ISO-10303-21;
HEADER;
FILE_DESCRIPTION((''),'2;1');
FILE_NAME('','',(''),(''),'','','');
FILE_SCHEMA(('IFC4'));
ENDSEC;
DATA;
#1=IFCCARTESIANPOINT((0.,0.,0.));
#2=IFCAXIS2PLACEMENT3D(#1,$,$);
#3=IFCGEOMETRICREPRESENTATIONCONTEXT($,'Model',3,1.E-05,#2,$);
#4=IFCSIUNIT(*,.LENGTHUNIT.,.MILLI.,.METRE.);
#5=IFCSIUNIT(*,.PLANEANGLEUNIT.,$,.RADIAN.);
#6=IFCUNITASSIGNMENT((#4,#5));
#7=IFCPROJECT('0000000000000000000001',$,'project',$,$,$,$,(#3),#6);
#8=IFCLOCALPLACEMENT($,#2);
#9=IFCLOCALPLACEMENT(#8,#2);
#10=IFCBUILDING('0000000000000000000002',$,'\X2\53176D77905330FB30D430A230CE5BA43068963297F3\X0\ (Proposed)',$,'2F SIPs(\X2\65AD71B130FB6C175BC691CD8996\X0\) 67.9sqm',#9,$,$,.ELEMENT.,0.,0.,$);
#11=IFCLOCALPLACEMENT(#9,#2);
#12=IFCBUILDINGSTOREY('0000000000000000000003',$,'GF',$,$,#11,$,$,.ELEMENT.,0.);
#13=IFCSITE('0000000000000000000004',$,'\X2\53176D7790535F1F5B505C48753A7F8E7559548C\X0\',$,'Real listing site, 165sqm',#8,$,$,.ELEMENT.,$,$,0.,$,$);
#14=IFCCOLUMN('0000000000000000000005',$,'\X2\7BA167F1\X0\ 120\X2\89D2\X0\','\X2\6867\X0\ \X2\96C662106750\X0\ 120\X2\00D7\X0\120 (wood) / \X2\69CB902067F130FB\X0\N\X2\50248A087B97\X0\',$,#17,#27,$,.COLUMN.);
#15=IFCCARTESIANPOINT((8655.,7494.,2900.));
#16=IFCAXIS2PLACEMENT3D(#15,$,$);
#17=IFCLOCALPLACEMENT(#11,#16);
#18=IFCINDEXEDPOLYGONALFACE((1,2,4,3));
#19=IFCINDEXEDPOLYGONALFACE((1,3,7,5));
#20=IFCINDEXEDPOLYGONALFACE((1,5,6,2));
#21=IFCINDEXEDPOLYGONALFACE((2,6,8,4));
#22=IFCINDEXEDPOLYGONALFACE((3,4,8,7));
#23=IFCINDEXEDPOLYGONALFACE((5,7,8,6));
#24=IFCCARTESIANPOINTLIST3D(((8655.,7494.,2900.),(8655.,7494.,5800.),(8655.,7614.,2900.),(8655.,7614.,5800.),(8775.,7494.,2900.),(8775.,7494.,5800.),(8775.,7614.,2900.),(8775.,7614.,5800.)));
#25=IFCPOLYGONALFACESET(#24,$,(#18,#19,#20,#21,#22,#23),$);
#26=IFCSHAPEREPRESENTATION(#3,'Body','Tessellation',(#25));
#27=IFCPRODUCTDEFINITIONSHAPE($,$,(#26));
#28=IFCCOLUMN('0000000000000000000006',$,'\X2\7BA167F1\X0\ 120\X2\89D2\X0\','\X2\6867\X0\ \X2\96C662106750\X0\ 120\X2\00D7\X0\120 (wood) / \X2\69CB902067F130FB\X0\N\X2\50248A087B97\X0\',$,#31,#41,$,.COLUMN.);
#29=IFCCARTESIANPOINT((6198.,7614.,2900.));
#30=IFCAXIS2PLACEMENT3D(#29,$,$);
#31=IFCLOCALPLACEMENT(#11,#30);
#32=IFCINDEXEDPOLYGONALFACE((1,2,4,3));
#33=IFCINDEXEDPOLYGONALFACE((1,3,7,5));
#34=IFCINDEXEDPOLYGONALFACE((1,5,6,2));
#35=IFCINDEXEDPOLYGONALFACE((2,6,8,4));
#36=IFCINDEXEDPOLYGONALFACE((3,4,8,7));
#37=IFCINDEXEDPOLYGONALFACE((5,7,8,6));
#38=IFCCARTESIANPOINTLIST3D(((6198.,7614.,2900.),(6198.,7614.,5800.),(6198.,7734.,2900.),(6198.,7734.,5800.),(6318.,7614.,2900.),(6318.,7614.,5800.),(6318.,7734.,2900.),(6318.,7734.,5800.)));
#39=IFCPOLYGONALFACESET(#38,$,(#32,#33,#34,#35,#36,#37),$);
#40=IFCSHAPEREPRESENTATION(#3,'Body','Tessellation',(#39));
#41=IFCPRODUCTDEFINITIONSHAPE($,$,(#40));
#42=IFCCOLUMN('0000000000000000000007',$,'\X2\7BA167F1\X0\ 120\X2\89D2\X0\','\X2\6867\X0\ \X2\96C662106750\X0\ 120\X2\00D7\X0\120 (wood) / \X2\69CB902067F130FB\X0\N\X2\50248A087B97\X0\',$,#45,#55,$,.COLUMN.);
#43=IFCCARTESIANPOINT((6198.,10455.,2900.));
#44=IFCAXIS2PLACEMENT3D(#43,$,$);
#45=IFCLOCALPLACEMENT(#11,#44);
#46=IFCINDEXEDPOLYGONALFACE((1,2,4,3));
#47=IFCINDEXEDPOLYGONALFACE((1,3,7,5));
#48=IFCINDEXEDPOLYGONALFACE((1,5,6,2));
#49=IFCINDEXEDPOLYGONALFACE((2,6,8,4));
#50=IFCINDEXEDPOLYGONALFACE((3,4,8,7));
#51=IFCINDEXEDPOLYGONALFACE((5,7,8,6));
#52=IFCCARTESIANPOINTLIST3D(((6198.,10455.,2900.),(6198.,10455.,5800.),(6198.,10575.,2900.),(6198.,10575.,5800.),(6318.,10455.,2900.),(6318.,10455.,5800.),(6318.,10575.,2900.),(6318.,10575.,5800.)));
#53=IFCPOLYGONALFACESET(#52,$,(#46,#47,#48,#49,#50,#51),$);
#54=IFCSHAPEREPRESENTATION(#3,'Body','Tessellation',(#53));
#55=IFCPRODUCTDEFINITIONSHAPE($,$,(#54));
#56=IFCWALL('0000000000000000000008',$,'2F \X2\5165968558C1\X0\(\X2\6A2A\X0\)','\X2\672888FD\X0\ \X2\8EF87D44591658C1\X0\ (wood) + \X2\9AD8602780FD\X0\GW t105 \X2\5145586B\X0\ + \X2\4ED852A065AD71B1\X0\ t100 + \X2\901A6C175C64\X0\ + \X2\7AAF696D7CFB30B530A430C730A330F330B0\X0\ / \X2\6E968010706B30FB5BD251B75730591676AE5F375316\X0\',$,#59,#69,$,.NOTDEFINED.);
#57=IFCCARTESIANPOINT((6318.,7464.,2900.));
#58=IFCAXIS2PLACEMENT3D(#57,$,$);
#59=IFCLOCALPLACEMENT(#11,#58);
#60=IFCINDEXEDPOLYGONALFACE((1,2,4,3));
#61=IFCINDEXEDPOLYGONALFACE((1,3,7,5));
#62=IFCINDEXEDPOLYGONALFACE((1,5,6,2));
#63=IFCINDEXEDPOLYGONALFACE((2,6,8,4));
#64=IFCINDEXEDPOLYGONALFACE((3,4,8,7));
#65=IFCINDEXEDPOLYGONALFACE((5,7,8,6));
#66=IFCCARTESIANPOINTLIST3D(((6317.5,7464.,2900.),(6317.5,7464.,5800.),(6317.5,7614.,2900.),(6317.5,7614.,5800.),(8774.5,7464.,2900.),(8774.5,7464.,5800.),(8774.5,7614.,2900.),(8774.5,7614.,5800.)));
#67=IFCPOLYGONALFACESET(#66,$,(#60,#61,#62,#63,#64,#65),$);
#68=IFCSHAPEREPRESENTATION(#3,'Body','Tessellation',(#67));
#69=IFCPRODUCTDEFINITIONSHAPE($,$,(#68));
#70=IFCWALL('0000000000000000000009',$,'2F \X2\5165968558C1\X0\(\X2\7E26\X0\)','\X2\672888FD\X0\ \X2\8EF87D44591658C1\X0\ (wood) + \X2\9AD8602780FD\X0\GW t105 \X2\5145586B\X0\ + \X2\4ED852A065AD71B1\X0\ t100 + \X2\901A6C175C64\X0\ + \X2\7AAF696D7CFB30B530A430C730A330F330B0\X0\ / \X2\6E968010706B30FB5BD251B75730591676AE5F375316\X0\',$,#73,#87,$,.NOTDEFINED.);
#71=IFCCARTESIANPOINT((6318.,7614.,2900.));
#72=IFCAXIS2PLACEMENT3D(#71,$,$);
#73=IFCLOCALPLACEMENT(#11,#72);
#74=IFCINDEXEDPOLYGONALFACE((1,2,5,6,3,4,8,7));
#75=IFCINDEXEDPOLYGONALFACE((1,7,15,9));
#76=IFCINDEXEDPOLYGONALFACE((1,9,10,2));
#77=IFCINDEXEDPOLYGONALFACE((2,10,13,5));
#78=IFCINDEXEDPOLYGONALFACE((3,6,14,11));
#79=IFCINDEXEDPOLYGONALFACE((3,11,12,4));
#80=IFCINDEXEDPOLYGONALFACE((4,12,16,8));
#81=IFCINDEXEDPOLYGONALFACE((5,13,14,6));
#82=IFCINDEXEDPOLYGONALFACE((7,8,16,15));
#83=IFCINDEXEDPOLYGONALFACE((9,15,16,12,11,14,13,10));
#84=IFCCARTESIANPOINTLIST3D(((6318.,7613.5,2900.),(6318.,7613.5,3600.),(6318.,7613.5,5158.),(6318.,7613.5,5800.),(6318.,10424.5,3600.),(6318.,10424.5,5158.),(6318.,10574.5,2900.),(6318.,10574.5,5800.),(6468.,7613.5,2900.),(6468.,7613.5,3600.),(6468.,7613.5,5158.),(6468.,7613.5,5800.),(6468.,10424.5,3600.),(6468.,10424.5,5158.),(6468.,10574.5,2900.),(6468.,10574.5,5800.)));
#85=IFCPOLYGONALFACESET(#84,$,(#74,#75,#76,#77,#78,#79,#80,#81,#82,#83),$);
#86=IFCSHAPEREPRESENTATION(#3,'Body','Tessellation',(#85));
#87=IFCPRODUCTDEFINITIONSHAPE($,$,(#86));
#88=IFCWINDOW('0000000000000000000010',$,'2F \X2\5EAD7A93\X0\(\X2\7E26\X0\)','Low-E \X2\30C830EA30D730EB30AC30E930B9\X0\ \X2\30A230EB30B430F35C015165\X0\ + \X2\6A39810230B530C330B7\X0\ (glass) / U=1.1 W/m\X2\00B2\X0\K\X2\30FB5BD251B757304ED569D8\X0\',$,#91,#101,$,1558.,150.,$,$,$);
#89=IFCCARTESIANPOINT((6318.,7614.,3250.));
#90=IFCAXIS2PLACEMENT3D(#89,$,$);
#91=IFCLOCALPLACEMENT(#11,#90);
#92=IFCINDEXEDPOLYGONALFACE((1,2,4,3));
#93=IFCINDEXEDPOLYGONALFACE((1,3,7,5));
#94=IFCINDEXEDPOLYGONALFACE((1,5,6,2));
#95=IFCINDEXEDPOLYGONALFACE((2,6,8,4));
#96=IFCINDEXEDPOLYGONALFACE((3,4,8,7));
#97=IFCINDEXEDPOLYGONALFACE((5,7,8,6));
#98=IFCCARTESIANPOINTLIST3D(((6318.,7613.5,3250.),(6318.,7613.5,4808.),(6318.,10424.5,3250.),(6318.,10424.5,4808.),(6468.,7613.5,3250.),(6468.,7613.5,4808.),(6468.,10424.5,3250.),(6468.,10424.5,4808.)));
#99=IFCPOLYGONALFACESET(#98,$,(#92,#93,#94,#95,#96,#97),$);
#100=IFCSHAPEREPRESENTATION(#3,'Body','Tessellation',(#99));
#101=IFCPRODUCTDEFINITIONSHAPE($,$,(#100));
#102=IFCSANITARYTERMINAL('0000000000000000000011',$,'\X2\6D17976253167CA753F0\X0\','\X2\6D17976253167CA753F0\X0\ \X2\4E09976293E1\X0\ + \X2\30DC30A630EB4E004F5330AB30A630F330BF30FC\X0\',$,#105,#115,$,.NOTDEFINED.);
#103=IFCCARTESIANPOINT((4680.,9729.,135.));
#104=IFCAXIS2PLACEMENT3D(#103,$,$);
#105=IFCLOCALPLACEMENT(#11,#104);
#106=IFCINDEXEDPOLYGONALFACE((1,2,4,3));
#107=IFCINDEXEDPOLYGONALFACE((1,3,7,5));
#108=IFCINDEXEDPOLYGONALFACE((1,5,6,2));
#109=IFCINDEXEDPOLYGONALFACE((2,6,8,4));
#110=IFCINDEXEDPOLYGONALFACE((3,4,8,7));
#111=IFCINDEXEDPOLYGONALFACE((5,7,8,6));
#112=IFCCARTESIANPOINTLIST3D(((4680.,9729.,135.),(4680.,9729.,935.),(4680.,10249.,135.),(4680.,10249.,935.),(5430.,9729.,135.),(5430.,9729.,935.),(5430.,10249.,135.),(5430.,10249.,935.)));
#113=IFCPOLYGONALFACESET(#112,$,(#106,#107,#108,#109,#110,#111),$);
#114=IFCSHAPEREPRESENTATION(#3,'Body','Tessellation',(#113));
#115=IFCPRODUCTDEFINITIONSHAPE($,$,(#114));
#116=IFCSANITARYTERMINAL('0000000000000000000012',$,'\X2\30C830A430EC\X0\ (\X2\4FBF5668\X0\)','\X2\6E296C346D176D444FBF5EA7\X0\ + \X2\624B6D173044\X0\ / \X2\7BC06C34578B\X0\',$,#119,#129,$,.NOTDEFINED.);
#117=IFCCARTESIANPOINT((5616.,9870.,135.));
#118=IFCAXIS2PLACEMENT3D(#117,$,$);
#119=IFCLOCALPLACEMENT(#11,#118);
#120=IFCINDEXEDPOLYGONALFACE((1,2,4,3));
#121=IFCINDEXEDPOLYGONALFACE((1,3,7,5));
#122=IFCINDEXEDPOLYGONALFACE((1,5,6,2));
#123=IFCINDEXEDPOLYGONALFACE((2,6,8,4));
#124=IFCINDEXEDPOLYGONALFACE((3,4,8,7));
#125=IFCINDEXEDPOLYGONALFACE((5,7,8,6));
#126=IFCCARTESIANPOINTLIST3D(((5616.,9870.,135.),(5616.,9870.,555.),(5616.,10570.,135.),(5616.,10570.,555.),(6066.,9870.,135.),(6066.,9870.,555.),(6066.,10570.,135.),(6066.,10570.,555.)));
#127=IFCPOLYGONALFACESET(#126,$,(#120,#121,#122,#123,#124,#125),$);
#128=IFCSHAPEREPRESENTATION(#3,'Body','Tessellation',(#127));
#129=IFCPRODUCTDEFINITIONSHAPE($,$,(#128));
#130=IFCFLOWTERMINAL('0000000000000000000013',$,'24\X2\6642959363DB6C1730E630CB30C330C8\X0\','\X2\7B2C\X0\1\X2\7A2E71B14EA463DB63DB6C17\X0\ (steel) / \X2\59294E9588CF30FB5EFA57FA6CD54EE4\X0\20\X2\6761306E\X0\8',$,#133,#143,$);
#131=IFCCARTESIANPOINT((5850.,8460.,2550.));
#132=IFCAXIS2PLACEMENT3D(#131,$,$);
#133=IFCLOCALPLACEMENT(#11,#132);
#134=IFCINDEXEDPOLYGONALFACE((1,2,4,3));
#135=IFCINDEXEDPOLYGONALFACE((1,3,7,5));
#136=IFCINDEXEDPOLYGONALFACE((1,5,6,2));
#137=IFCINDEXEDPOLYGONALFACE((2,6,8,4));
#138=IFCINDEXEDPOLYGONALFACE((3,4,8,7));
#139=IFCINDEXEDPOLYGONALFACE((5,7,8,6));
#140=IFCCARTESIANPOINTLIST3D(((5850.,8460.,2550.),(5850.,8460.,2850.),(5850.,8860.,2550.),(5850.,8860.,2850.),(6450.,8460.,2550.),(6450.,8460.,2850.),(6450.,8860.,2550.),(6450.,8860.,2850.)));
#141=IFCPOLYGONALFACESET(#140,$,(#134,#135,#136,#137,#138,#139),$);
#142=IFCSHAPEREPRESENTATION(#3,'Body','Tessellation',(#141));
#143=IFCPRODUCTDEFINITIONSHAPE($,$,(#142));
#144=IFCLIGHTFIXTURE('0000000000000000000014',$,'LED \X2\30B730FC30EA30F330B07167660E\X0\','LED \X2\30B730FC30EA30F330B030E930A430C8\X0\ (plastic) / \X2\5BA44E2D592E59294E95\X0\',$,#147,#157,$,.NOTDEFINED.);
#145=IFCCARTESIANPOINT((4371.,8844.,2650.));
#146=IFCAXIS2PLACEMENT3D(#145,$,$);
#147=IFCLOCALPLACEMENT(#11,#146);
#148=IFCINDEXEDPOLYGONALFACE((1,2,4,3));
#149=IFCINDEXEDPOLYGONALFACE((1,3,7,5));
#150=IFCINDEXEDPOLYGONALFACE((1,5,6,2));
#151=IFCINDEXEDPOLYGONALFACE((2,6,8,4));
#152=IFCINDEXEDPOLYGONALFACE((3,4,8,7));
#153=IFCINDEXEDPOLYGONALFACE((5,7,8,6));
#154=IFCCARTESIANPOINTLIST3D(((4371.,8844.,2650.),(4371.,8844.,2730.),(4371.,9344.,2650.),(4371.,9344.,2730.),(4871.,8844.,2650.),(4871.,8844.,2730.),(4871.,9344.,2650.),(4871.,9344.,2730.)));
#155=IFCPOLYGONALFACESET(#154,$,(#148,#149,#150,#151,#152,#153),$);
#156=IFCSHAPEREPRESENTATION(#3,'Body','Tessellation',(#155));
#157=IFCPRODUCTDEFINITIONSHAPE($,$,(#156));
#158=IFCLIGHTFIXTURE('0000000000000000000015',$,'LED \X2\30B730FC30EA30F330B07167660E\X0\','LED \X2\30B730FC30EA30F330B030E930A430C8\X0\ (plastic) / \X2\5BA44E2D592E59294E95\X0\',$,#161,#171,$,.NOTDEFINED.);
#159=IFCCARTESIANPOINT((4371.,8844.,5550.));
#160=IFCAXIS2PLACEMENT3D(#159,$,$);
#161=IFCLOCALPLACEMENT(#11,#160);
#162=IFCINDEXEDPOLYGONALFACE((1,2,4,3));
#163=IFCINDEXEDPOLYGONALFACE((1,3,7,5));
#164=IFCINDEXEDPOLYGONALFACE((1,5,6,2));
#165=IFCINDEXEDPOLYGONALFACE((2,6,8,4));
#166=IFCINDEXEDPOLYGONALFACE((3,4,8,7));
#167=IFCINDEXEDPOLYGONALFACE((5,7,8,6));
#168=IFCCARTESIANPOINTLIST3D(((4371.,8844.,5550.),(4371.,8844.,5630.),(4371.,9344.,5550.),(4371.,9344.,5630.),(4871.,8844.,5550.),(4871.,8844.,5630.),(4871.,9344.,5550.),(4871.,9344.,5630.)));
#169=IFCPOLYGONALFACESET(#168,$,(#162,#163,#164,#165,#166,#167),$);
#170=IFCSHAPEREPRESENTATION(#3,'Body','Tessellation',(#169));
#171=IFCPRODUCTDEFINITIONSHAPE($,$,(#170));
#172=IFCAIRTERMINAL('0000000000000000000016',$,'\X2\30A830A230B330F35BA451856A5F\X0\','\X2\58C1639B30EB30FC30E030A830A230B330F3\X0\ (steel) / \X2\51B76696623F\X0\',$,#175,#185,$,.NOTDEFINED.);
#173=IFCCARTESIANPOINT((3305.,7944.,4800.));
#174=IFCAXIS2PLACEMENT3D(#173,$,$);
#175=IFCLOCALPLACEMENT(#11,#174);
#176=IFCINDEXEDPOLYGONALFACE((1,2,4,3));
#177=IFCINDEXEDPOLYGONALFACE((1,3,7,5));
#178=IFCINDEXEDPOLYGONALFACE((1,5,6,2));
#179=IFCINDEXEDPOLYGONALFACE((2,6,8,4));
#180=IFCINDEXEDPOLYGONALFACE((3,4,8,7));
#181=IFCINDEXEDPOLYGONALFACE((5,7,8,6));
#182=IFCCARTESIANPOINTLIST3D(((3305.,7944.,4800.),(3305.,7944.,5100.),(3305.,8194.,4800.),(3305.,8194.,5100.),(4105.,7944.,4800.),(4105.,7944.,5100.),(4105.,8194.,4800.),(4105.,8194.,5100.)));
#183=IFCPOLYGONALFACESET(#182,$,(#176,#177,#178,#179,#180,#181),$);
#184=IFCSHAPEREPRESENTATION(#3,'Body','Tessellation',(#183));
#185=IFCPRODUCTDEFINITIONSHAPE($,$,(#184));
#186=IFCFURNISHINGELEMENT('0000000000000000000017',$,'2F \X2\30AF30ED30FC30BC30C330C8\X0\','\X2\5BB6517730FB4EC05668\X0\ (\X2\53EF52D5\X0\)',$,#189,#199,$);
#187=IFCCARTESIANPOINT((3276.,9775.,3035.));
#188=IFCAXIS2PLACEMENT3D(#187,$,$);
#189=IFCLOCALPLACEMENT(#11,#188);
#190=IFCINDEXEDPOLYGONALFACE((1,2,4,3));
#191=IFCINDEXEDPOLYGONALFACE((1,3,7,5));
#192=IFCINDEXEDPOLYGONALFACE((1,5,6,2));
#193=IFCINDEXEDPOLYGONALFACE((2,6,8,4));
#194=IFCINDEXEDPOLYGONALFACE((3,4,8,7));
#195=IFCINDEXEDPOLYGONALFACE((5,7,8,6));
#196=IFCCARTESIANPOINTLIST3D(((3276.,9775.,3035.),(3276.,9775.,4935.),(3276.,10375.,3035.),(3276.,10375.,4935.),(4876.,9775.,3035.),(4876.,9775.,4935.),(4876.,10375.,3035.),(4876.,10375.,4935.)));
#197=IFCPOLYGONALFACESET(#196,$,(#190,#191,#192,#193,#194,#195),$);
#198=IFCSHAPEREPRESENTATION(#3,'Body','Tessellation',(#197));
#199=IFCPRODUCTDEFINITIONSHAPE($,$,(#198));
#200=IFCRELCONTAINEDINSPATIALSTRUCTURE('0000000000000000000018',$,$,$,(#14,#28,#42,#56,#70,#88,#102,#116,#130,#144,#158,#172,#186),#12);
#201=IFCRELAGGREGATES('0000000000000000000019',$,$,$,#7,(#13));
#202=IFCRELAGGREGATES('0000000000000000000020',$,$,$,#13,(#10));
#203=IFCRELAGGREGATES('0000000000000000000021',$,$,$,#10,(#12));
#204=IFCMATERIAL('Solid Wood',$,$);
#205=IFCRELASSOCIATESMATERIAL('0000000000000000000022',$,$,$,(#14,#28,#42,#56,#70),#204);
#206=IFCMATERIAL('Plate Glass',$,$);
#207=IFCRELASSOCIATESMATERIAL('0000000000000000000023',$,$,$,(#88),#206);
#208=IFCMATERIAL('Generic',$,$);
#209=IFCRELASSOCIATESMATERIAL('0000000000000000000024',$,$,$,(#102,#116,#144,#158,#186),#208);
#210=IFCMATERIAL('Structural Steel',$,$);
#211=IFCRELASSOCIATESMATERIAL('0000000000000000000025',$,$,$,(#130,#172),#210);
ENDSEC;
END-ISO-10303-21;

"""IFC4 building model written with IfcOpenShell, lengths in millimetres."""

from ifc_helpers import new_model, si_unit, frame, frame_2d, origin, place, context, project, spatial, rectangle, extrude, material, element, fill, save


model = new_model("IFC4")

# Units and contexts
model_context = context("Model", 3, precision=1e-05, world=origin())
ifc_project = project(units=[si_unit("LENGTHUNIT", "METRE", prefix="MILLI"), si_unit("PLANEANGLEUNIT", "RADIAN")], contexts=[model_context])

# Site, building, storey
site_placement = place(None, origin())
site = spatial("IfcSite", under=ifc_project, at=site_placement, Name="北海道弟子屈町美留和", ObjectType="Real listing site, 165sqm", CompositionType="ELEMENT", RefElevation=0.0)
building_placement = place(site_placement, origin())
building = spatial("IfcBuilding", under=site, at=building_placement, Name="北海道・ピアノ室と防音 (Proposed)", ObjectType="2F SIPs(断熱・気密重視) 67.9sqm", CompositionType="ELEMENT", ElevationOfRefHeight=0.0, ElevationOfTerrain=0.0)
storey_placement = place(building_placement, origin())
storey = spatial("IfcBuildingStorey", under=building, at=storey_placement, Name="GF", CompositionType="ELEMENT", Elevation=0.0)

# Columns
ifc_material_1 = material(Name="Solid Wood")
column_1_placement = place(storey_placement, frame((8655.0, 7494.0, 2900.0)))
element("IfcColumn", 1, at=column_1_placement, inside=storey, material=ifc_material_1, Name="管柱 120角", Description="桧 集成材 120×120 (wood) / 構造柱・N値計算", PredefinedType="COLUMN", context=model_context, shape_type="SweptSolid", body=[
    extrude(rectangle(XDim=120.0, YDim=120.0, at=frame_2d((60.0, 60.0))), frame((8655.0, 7494.0, 2900.0)), (0.0, 0.0, 1.0), 2900.0),
])
column_2_placement = place(storey_placement, frame((6198.0, 7614.0, 2900.0)))
element("IfcColumn", 2, at=column_2_placement, inside=storey, material=ifc_material_1, Name="管柱 120角", Description="桧 集成材 120×120 (wood) / 構造柱・N値計算", PredefinedType="COLUMN", context=model_context, shape_type="SweptSolid", body=[
    extrude(rectangle(XDim=120.0, YDim=120.0, at=frame_2d((60.0, 60.0))), frame((6198.0, 7614.0, 2900.0)), (0.0, 0.0, 1.0), 2900.0),
])
column_3_placement = place(storey_placement, frame((6198.0, 10455.0, 2900.0)))
element("IfcColumn", 3, at=column_3_placement, inside=storey, material=ifc_material_1, Name="管柱 120角", Description="桧 集成材 120×120 (wood) / 構造柱・N値計算", PredefinedType="COLUMN", context=model_context, shape_type="SweptSolid", body=[
    extrude(rectangle(XDim=120.0, YDim=120.0, at=frame_2d((60.0, 60.0))), frame((6198.0, 10455.0, 2900.0)), (0.0, 0.0, 1.0), 2900.0),
])

# Wall
wall_1_placement = place(storey_placement, frame((6318.0, 7464.0, 2900.0)))
element("IfcWall", 4, at=wall_1_placement, inside=storey, material=ifc_material_1, Name="2F 入隅壁(横)", Description="木製 軸組外壁 (wood) + 高性能GW t105 充填 + 付加断熱 t100 + 通気層 + 窯業系サイディング / 準耐火・寒冷地外皮強化", PredefinedType="NOTDEFINED", context=model_context, shape_type="SweptSolid", body=[
    extrude(rectangle(XDim=2457.0, YDim=150.0, at=frame_2d((1228.0, 75.0))), frame((6318.0, 7464.0, 2900.0)), (0.0, 0.0, 1.0), 2900.0),
])

# Wall, opening, window
wall_2_placement = place(storey_placement, frame((6318.0, 7614.0, 2900.0)))
wall_2 = element("IfcWall", 5, at=wall_2_placement, inside=storey, material=ifc_material_1, Name="2F 入隅壁(縦)", Description="木製 軸組外壁 (wood) + 高性能GW t105 充填 + 付加断熱 t100 + 通気層 + 窯業系サイディング / 準耐火・寒冷地外皮強化", PredefinedType="NOTDEFINED", context=model_context, shape_type="SweptSolid", body=[
    extrude(rectangle(XDim=150.0, YDim=2961.0, at=frame_2d((75.0, 1480.0))), frame((6318.0, 7614.0, 2900.0)), (0.0, 0.0, 1.0), 2900.0),
])
opening_placement = place(storey_placement, frame((6318.0, 7614.0, 3250.0)))
opening = element("IfcOpeningElement", 6, at=opening_placement, cuts=wall_2, PredefinedType="NOTDEFINED", context=model_context, shape_type="SweptSolid", body=[
    extrude(rectangle(XDim=150.0, YDim=2811.0, at=frame_2d((75.0, 1405.0))), frame((6318.0, 7614.0, 3250.0)), (0.0, 0.0, 1.0), 1558.0),
])
ifc_material_2 = material(Name="Plate Glass")
window_placement = place(storey_placement, frame((6318.0, 7614.0, 3250.0)))
window = element("IfcWindow", 7, at=window_placement, inside=storey, material=ifc_material_2, Name="2F 庭窓(縦)", Description="Low-E トリプルガラス アルゴン封入 + 樹脂サッシ (glass) / U=1.1 W/m²K・寒冷地仕様", OverallHeight=1558.0, OverallWidth=150.0, context=model_context, shape_type="SweptSolid", body=[
    extrude(rectangle(XDim=150.0, YDim=2811.0, at=frame_2d((75.0, 1405.0))), frame((6318.0, 7614.0, 3250.0)), (0.0, 0.0, 1.0), 1558.0),
])
fill(opening, window)

# Sanitary terminals
ifc_material_3 = material(Name="Generic")
sanitary_terminal_1_placement = place(storey_placement, frame((4680.0, 9729.0, 135.0)))
element("IfcSanitaryTerminal", 8, at=sanitary_terminal_1_placement, inside=storey, material=ifc_material_3, Name="洗面化粧台", Description="洗面化粧台 三面鏡 + ボウル一体カウンター", PredefinedType="NOTDEFINED", context=model_context, shape_type="SweptSolid", body=[
    extrude(rectangle(XDim=750.0, YDim=520.0, at=frame_2d((375.0, 260.0))), frame((4680.0, 9729.0, 135.0)), (0.0, 0.0, 1.0), 800.0),
])
sanitary_terminal_2_placement = place(storey_placement, frame((5616.0, 9870.0, 135.0)))
element("IfcSanitaryTerminal", 9, at=sanitary_terminal_2_placement, inside=storey, material=ifc_material_3, Name="トイレ (便器)", Description="温水洗浄便座 + 手洗い / 節水型", PredefinedType="NOTDEFINED", context=model_context, shape_type="SweptSolid", body=[
    extrude(rectangle(XDim=450.0, YDim=700.0, at=frame_2d((225.0, 350.0))), frame((5616.0, 9870.0, 135.0)), (0.0, 0.0, 1.0), 420.0),
])

# Flow terminal
ifc_material_4 = material(Name="Structural Steel")
flow_terminal_placement = place(storey_placement, frame((5850.0, 8460.0, 2550.0)))
element("IfcFlowTerminal", 10, at=flow_terminal_placement, inside=storey, material=ifc_material_4, Name="24時間換気ユニット", Description="第1種熱交換換気 (steel) / 天井裏・建基法令20条の8", context=model_context, shape_type="SweptSolid", body=[
    extrude(rectangle(XDim=600.0, YDim=400.0, at=frame_2d((300.0, 200.0))), frame((5850.0, 8460.0, 2550.0)), (0.0, 0.0, 1.0), 300.0),
])

# Light fixtures
light_fixture_1_placement = place(storey_placement, frame((4371.0, 8844.0, 2650.0)))
element("IfcLightFixture", 11, at=light_fixture_1_placement, inside=storey, material=ifc_material_3, Name="LED シーリング照明", Description="LED シーリングライト (plastic) / 室中央天井", PredefinedType="NOTDEFINED", context=model_context, shape_type="SweptSolid", body=[
    extrude(rectangle(XDim=500.0, YDim=500.0, at=frame_2d((250.0, 250.0))), frame((4371.0, 8844.0, 2650.0)), (0.0, 0.0, 1.0), 80.0),
])
light_fixture_2_placement = place(storey_placement, frame((4371.0, 8844.0, 5550.0)))
element("IfcLightFixture", 12, at=light_fixture_2_placement, inside=storey, material=ifc_material_3, Name="LED シーリング照明", Description="LED シーリングライト (plastic) / 室中央天井", PredefinedType="NOTDEFINED", context=model_context, shape_type="SweptSolid", body=[
    extrude(rectangle(XDim=500.0, YDim=500.0, at=frame_2d((250.0, 250.0))), frame((4371.0, 8844.0, 5550.0)), (0.0, 0.0, 1.0), 80.0),
])

# Air terminal
air_terminal_placement = place(storey_placement, frame((3305.0, 7944.0, 4800.0)))
element("IfcAirTerminal", 13, at=air_terminal_placement, inside=storey, material=ifc_material_4, Name="エアコン室内機", Description="壁掛ルームエアコン (steel) / 冷暖房", PredefinedType="NOTDEFINED", context=model_context, shape_type="SweptSolid", body=[
    extrude(rectangle(XDim=800.0, YDim=250.0, at=frame_2d((400.0, 125.0))), frame((3305.0, 7944.0, 4800.0)), (0.0, 0.0, 1.0), 300.0),
])

# Furnishing element
furnishing_1_placement = place(storey_placement, frame((3276.0, 9775.0, 3035.0)))
element("IfcFurnishingElement", 14, at=furnishing_1_placement, inside=storey, material=ifc_material_3, Name="2F クローゼット", Description="家具・什器 (可動)", context=model_context, shape_type="SweptSolid", body=[
    extrude(rectangle(XDim=1600.0, YDim=600.0, at=frame_2d((800.0, 300.0))), frame((3276.0, 9775.0, 3035.0)), (0.0, 0.0, 1.0), 1900.0),
])

save(model, "model.ifc")
